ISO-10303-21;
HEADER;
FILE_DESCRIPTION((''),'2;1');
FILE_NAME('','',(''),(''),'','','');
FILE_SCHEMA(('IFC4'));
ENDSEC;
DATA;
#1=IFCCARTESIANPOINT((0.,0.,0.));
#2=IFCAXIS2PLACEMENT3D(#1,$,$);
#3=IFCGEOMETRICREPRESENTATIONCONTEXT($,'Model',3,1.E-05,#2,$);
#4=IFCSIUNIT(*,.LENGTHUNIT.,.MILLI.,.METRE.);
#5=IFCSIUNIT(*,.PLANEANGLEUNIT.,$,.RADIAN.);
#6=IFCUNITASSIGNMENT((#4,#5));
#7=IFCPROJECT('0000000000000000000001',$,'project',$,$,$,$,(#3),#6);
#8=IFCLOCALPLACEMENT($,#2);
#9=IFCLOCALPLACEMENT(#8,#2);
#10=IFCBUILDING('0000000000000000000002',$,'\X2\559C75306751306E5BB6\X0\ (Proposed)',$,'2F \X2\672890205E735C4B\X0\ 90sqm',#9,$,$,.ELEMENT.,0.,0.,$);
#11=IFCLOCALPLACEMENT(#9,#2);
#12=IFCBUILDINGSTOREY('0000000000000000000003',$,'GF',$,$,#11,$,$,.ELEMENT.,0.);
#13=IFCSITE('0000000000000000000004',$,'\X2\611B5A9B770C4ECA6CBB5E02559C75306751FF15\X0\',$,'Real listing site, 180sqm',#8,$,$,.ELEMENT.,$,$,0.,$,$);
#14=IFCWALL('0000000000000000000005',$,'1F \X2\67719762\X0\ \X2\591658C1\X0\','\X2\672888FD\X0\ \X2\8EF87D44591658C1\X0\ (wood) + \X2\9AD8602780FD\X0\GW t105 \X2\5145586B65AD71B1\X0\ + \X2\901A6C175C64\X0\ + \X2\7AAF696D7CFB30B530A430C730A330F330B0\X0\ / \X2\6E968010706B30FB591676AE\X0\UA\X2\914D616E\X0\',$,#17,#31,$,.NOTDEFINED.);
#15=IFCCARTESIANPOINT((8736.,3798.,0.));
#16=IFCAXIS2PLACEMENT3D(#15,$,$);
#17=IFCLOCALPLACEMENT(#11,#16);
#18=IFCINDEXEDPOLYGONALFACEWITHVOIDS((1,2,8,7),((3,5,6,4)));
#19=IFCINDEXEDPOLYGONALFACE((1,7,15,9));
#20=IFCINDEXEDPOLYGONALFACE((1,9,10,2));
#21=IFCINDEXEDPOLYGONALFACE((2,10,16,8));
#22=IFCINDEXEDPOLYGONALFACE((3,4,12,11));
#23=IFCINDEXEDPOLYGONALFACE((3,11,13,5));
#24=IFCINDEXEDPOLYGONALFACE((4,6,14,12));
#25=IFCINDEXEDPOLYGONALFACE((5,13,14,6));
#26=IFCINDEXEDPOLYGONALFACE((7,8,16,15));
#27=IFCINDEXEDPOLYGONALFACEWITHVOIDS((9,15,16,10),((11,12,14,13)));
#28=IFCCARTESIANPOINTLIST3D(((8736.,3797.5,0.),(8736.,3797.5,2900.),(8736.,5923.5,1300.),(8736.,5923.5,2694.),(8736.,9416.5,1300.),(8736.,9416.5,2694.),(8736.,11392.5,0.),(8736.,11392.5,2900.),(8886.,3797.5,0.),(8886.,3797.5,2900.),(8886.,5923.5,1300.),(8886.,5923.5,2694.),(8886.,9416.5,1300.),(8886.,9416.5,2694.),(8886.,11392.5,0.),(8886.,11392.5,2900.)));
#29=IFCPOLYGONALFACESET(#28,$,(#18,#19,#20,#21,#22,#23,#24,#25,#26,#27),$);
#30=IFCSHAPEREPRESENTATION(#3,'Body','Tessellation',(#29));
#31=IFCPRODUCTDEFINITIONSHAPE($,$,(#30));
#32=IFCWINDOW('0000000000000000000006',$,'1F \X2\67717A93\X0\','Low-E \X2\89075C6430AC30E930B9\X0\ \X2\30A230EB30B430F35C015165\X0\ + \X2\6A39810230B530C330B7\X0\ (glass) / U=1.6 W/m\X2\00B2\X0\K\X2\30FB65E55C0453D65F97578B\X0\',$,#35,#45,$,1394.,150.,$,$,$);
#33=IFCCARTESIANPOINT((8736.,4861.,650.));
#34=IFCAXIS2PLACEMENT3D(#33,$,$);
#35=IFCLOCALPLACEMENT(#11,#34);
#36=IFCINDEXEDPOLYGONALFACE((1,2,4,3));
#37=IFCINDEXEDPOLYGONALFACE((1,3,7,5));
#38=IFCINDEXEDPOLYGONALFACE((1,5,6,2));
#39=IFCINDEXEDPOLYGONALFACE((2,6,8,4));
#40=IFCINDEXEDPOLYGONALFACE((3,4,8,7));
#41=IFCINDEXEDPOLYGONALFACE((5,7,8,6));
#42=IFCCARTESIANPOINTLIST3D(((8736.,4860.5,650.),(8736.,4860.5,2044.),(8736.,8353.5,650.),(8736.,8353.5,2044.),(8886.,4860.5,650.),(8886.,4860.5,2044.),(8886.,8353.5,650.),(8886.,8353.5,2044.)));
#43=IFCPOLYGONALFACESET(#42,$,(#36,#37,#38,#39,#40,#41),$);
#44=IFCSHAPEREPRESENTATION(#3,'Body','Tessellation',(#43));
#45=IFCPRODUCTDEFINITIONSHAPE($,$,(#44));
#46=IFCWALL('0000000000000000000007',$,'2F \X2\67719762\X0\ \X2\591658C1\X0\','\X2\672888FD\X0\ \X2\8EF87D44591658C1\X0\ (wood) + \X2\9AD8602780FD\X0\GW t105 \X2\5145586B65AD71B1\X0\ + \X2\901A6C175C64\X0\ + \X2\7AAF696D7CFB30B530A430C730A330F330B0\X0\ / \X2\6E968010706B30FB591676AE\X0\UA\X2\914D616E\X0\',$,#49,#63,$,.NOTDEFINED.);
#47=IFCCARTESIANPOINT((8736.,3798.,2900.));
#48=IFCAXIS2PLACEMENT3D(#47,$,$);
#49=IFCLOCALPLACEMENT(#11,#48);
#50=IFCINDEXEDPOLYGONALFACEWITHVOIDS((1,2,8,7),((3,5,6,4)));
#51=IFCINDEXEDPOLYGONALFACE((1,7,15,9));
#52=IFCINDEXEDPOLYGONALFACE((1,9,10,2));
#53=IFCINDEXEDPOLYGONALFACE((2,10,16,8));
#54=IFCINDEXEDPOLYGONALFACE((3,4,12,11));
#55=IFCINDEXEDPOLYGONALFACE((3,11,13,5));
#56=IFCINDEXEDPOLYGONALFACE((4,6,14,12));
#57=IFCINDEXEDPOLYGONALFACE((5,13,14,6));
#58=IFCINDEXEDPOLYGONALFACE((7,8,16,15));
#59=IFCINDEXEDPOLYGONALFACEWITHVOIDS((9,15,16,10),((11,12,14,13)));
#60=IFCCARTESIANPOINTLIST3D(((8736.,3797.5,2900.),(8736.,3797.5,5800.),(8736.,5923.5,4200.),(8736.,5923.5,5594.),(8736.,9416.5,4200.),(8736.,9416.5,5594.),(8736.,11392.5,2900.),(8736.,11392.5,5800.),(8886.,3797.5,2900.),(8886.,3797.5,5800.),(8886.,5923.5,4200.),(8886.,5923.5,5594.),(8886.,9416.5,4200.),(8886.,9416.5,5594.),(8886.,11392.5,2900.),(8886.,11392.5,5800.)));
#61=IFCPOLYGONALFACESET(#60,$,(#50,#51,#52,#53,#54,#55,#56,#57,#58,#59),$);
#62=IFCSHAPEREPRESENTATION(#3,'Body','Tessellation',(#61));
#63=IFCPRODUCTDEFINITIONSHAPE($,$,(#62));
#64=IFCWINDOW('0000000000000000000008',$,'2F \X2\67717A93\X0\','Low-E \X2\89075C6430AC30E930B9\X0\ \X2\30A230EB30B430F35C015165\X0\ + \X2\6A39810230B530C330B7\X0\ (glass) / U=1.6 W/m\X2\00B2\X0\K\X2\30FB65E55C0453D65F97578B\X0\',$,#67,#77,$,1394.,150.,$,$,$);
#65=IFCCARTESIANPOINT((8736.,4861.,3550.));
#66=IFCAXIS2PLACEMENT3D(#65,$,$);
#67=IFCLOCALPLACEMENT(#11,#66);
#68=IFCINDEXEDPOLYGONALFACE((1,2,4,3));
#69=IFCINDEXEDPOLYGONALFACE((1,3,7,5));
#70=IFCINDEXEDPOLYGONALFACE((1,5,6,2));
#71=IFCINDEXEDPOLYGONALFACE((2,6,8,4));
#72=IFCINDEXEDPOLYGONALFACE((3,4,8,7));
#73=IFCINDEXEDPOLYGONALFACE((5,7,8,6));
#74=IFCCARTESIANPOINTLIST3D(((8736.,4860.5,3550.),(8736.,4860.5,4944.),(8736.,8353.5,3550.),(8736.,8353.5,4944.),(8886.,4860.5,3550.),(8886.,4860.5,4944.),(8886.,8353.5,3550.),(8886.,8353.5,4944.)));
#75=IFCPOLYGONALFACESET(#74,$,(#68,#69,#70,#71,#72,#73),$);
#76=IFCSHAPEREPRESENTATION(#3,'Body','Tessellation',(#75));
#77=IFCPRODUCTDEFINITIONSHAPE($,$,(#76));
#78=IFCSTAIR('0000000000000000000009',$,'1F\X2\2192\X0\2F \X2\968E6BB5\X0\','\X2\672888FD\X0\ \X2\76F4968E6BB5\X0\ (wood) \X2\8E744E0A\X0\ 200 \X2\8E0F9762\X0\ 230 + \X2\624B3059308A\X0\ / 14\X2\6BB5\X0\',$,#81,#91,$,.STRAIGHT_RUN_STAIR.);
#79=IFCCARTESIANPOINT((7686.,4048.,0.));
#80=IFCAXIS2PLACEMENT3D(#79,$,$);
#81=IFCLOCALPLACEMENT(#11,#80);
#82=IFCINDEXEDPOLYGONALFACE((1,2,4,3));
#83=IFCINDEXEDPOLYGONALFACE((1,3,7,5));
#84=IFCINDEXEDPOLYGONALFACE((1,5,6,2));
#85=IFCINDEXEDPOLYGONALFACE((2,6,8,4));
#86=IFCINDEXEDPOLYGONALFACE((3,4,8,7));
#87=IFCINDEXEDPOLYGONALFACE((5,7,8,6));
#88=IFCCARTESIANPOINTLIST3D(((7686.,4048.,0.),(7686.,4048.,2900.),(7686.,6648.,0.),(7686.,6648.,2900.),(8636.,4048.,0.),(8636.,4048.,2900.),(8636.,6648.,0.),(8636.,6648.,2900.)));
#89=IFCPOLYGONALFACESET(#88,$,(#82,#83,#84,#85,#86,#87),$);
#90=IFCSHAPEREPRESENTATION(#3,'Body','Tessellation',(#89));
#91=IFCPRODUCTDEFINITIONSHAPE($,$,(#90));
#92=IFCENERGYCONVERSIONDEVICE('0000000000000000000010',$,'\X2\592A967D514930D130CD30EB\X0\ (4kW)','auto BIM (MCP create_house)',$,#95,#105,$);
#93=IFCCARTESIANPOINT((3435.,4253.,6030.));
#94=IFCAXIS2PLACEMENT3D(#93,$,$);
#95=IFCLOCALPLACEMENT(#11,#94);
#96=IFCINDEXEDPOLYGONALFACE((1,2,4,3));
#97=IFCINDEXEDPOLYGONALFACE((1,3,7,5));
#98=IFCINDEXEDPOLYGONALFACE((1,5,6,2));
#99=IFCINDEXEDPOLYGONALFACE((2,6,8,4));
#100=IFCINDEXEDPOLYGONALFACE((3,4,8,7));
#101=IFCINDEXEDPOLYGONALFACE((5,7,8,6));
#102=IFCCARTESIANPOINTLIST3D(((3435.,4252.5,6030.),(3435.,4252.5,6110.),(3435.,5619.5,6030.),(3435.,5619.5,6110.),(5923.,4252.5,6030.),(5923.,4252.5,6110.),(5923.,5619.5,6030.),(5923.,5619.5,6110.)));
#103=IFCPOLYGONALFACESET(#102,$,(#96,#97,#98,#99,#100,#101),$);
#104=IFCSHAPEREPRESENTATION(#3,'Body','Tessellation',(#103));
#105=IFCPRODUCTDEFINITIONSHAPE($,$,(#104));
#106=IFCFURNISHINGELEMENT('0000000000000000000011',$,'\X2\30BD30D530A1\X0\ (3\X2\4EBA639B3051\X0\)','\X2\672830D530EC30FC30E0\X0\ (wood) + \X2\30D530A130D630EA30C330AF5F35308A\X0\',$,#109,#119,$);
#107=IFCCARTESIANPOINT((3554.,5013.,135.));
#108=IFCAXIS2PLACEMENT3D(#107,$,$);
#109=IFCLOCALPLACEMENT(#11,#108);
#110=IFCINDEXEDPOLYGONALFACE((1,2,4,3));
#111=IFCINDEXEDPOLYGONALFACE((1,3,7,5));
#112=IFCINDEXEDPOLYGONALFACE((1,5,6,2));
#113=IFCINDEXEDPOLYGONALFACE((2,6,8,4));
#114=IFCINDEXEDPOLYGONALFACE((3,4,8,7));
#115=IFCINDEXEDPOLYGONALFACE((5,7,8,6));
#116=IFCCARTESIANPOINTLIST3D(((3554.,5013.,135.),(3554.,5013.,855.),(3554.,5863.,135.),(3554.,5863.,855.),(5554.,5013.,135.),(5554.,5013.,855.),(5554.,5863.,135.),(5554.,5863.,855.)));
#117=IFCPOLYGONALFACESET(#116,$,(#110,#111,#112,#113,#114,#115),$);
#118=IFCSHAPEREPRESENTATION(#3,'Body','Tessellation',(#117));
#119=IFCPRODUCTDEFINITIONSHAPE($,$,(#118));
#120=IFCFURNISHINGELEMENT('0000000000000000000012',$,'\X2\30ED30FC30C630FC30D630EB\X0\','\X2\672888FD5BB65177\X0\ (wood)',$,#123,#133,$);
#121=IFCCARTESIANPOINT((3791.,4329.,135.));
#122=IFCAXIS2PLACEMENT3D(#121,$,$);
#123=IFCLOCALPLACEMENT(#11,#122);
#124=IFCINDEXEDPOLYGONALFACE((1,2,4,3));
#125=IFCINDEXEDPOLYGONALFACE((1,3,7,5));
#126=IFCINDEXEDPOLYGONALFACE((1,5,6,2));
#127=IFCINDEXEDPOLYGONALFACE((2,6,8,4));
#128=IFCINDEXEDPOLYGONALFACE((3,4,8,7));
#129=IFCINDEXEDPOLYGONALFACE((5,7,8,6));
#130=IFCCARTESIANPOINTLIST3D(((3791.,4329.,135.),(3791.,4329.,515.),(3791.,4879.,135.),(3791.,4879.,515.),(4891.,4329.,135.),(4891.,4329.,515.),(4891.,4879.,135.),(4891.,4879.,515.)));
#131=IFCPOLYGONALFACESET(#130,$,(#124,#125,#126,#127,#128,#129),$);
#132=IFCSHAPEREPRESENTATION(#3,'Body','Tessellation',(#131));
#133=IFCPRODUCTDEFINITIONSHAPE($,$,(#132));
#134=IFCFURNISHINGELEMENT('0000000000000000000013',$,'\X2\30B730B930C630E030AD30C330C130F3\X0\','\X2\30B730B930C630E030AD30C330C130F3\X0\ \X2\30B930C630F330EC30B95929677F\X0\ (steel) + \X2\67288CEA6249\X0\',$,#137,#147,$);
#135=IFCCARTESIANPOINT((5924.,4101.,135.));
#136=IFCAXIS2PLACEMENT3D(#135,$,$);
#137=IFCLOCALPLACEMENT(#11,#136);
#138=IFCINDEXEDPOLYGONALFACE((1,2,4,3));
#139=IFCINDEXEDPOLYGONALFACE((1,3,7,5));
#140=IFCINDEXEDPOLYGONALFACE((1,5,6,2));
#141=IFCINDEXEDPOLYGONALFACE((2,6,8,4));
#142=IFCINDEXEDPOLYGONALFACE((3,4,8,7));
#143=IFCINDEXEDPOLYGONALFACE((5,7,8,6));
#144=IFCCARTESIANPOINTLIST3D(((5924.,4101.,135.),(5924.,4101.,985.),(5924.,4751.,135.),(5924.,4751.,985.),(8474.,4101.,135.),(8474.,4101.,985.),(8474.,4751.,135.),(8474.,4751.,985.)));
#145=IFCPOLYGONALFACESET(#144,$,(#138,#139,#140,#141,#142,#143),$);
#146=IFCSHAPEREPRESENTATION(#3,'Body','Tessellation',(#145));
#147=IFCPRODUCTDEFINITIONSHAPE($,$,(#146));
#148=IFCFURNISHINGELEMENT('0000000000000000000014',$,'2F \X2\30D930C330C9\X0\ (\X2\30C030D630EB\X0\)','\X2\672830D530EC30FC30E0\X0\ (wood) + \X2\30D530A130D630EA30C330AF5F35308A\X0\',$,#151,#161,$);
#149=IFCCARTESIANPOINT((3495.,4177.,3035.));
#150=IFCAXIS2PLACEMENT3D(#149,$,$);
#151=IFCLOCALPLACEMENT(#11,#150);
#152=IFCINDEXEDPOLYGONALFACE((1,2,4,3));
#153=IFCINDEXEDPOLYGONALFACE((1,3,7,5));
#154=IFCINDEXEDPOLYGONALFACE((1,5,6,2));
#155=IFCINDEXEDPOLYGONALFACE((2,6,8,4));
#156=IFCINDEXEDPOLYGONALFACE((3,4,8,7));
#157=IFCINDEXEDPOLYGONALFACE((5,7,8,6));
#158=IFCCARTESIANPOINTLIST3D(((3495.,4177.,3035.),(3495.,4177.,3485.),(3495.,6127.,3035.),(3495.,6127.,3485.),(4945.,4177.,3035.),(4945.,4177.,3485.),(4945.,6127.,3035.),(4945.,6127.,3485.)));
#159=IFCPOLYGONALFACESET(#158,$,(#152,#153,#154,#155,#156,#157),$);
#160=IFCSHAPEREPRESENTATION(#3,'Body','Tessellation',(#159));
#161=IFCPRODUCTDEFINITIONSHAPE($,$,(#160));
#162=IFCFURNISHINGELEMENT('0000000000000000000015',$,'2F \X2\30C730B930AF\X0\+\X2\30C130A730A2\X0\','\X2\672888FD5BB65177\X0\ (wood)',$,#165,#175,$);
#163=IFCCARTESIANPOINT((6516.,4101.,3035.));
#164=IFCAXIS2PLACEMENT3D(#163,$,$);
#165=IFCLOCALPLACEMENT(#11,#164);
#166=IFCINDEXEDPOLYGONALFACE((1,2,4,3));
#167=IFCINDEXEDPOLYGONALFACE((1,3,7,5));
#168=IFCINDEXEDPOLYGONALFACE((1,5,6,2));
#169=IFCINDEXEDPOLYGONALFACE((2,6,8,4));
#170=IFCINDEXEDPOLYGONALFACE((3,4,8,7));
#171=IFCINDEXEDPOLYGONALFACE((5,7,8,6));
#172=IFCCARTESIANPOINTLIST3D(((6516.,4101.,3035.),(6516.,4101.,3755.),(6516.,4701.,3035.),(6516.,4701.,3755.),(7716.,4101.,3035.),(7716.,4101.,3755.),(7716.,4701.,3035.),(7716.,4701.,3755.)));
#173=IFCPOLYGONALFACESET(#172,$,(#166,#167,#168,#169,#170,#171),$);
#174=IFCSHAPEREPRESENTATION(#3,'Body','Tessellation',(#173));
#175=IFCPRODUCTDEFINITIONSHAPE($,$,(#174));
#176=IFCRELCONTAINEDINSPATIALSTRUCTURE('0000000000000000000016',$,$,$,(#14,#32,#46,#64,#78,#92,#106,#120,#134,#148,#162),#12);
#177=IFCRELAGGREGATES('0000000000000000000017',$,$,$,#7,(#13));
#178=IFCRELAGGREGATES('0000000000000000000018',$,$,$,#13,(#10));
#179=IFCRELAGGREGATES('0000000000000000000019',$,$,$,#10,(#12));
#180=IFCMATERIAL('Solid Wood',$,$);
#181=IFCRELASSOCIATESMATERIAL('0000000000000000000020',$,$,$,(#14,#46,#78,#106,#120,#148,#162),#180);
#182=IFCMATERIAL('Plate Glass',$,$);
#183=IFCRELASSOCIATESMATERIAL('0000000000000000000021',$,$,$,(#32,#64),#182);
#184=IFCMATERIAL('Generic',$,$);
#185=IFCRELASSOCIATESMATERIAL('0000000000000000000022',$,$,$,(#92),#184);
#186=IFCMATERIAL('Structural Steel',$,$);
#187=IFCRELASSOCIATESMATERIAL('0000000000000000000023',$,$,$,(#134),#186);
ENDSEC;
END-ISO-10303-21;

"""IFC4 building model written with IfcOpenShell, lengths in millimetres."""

from ifc_helpers import new_model, si_unit, frame, frame_2d, origin, place, context, project, spatial, rectangle, extrude, material, element, fill, save


model = new_model("IFC4")

# Units and contexts
model_context = context("Model", 3, precision=1e-05, world=origin())
ifc_project = project(units=[si_unit("LENGTHUNIT", "METRE", prefix="MILLI"), si_unit("PLANEANGLEUNIT", "RADIAN")], contexts=[model_context])

# Site, building, storey
site_placement = place(None, origin())
site = spatial("IfcSite", under=ifc_project, at=site_placement, Name="愛媛県今治市喜田村５", ObjectType="Real listing site, 180sqm", CompositionType="ELEMENT", RefElevation=0.0)
building_placement = place(site_placement, origin())
building = spatial("IfcBuilding", under=site, at=building_placement, Name="喜田村の家 (Proposed)", ObjectType="2F 木造平屋 90sqm", CompositionType="ELEMENT", ElevationOfRefHeight=0.0, ElevationOfTerrain=0.0)
storey_placement = place(building_placement, origin())
storey = spatial("IfcBuildingStorey", under=building, at=storey_placement, Name="GF", CompositionType="ELEMENT", Elevation=0.0)

# Wall, opening, window
ifc_material_1 = material(Name="Solid Wood")
wall_1_placement = place(storey_placement, frame((8736.0, 3798.0, 0.0)))
wall_1 = element("IfcWall", 1, at=wall_1_placement, inside=storey, material=ifc_material_1, Name="1F 東面 外壁", Description="木製 軸組外壁 (wood) + 高性能GW t105 充填断熱 + 通気層 + 窯業系サイディング / 準耐火・外皮UA配慮", PredefinedType="NOTDEFINED", context=model_context, shape_type="SweptSolid", body=[
    extrude(rectangle(XDim=150.0, YDim=7595.0, at=frame_2d((75.0, 3797.0))), frame((8736.0, 3798.0, 0.0)), (0.0, 0.0, 1.0), 2900.0),
])
opening_1_placement = place(storey_placement, frame((8736.0, 4861.0, 650.0)))
opening_1 = element("IfcOpeningElement", 2, at=opening_1_placement, cuts=wall_1, PredefinedType="NOTDEFINED", context=model_context, shape_type="SweptSolid", body=[
    extrude(rectangle(XDim=150.0, YDim=3493.0, at=frame_2d((75.0, 1746.0))), frame((8736.0, 4861.0, 650.0)), (0.0, 0.0, 1.0), 1394.0),
])
ifc_material_2 = material(Name="Plate Glass")
window_1_placement = place(storey_placement, frame((8736.0, 4861.0, 650.0)))
window_1 = element("IfcWindow", 3, at=window_1_placement, inside=storey, material=ifc_material_2, Name="1F 東窓", Description="Low-E 複層ガラス アルゴン封入 + 樹脂サッシ (glass) / U=1.6 W/m²K・日射取得型", OverallHeight=1394.0, OverallWidth=150.0, context=model_context, shape_type="SweptSolid", body=[
    extrude(rectangle(XDim=150.0, YDim=3493.0, at=frame_2d((75.0, 1746.0))), frame((8736.0, 4861.0, 650.0)), (0.0, 0.0, 1.0), 1394.0),
])
fill(opening_1, window_1)

# Wall, opening, window
wall_2_placement = place(storey_placement, frame((8736.0, 3798.0, 2900.0)))
wall_2 = element("IfcWall", 4, at=wall_2_placement, inside=storey, material=ifc_material_1, Name="2F 東面 外壁", Description="木製 軸組外壁 (wood) + 高性能GW t105 充填断熱 + 通気層 + 窯業系サイディング / 準耐火・外皮UA配慮", PredefinedType="NOTDEFINED", context=model_context, shape_type="SweptSolid", body=[
    extrude(rectangle(XDim=150.0, YDim=7595.0, at=frame_2d((75.0, 3797.0))), frame((8736.0, 3798.0, 2900.0)), (0.0, 0.0, 1.0), 2900.0),
])
opening_2_placement = place(storey_placement, frame((8736.0, 4861.0, 3550.0)))
opening_2 = element("IfcOpeningElement", 5, at=opening_2_placement, cuts=wall_2, PredefinedType="NOTDEFINED", context=model_context, shape_type="SweptSolid", body=[
    extrude(rectangle(XDim=150.0, YDim=3493.0, at=frame_2d((75.0, 1746.0))), frame((8736.0, 4861.0, 3550.0)), (0.0, 0.0, 1.0), 1394.0),
])
window_2_placement = place(storey_placement, frame((8736.0, 4861.0, 3550.0)))
window_2 = element("IfcWindow", 6, at=window_2_placement, inside=storey, material=ifc_material_2, Name="2F 東窓", Description="Low-E 複層ガラス アルゴン封入 + 樹脂サッシ (glass) / U=1.6 W/m²K・日射取得型", OverallHeight=1394.0, OverallWidth=150.0, context=model_context, shape_type="SweptSolid", body=[
    extrude(rectangle(XDim=150.0, YDim=3493.0, at=frame_2d((75.0, 1746.0))), frame((8736.0, 4861.0, 3550.0)), (0.0, 0.0, 1.0), 1394.0),
])
fill(opening_2, window_2)

# Stair
stair_placement = place(storey_placement, frame((7686.0, 4048.0, 0.0)))
element("IfcStair", 7, at=stair_placement, inside=storey, material=ifc_material_1, Name="1F→2F 階段", Description="木製 直階段 (wood) 蹴上 200 踏面 230 + 手すり / 14段", PredefinedType="STRAIGHT_RUN_STAIR", context=model_context, shape_type="SweptSolid", body=[
    extrude(rectangle(XDim=950.0, YDim=2600.0, at=frame_2d((475.0, 1300.0))), frame((7686.0, 4048.0, 0.0)), (0.0, 0.0, 1.0), 2900.0),
])

# Energy conversion device
ifc_material_3 = material(Name="Generic")
energy_conversion_device_placement = place(storey_placement, frame((3435.0, 4253.0, 6030.0)))
element("IfcEnergyConversionDevice", 8, at=energy_conversion_device_placement, inside=storey, material=ifc_material_3, Name="太陽光パネル (4kW)", Description="auto BIM (MCP create_house)", context=model_context, shape_type="SweptSolid", body=[
    extrude(rectangle(XDim=2488.0, YDim=1367.0, at=frame_2d((1244.0, 683.0))), frame((3435.0, 4253.0, 6030.0)), (0.0, 0.0, 1.0), 80.0),
])

# Furnishing elements
furnishing_1_placement = place(storey_placement, frame((3554.0, 5013.0, 135.0)))
element("IfcFurnishingElement", 9, at=furnishing_1_placement, inside=storey, material=ifc_material_1, Name="ソファ (3人掛け)", Description="木フレーム (wood) + ファブリック張り", context=model_context, shape_type="SweptSolid", body=[
    extrude(rectangle(XDim=2000.0, YDim=850.0, at=frame_2d((1000.0, 425.0))), frame((3554.0, 5013.0, 135.0)), (0.0, 0.0, 1.0), 720.0),
])
furnishing_2_placement = place(storey_placement, frame((3791.0, 4329.0, 135.0)))
element("IfcFurnishingElement", 10, at=furnishing_2_placement, inside=storey, material=ifc_material_1, Name="ローテーブル", Description="木製家具 (wood)", context=model_context, shape_type="SweptSolid", body=[
    extrude(rectangle(XDim=1100.0, YDim=550.0, at=frame_2d((550.0, 275.0))), frame((3791.0, 4329.0, 135.0)), (0.0, 0.0, 1.0), 380.0),
])
ifc_material_4 = material(Name="Structural Steel")
furnishing_3_placement = place(storey_placement, frame((5924.0, 4101.0, 135.0)))
element("IfcFurnishingElement", 11, at=furnishing_3_placement, inside=storey, material=ifc_material_4, Name="システムキッチン", Description="システムキッチン ステンレス天板 (steel) + 木質扉", context=model_context, shape_type="SweptSolid", body=[
    extrude(rectangle(XDim=2550.0, YDim=650.0, at=frame_2d((1275.0, 325.0))), frame((5924.0, 4101.0, 135.0)), (0.0, 0.0, 1.0), 850.0),
])
furnishing_4_placement = place(storey_placement, frame((3495.0, 4177.0, 3035.0)))
element("IfcFurnishingElement", 12, at=furnishing_4_placement, inside=storey, material=ifc_material_1, Name="2F ベッド (ダブル)", Description="木フレーム (wood) + ファブリック張り", context=model_context, shape_type="SweptSolid", body=[
    extrude(rectangle(XDim=1450.0, YDim=1950.0, at=frame_2d((725.0, 975.0))), frame((3495.0, 4177.0, 3035.0)), (0.0, 0.0, 1.0), 450.0),
])
furnishing_5_placement = place(storey_placement, frame((6516.0, 4101.0, 3035.0)))
element("IfcFurnishingElement", 13, at=furnishing_5_placement, inside=storey, material=ifc_material_1, Name="2F デスク+チェア", Description="木製家具 (wood)", context=model_context, shape_type="SweptSolid", body=[
    extrude(rectangle(XDim=1200.0, YDim=600.0, at=frame_2d((600.0, 300.0))), frame((6516.0, 4101.0, 3035.0)), (0.0, 0.0, 1.0), 720.0),
])

save(model, "model.ifc")
